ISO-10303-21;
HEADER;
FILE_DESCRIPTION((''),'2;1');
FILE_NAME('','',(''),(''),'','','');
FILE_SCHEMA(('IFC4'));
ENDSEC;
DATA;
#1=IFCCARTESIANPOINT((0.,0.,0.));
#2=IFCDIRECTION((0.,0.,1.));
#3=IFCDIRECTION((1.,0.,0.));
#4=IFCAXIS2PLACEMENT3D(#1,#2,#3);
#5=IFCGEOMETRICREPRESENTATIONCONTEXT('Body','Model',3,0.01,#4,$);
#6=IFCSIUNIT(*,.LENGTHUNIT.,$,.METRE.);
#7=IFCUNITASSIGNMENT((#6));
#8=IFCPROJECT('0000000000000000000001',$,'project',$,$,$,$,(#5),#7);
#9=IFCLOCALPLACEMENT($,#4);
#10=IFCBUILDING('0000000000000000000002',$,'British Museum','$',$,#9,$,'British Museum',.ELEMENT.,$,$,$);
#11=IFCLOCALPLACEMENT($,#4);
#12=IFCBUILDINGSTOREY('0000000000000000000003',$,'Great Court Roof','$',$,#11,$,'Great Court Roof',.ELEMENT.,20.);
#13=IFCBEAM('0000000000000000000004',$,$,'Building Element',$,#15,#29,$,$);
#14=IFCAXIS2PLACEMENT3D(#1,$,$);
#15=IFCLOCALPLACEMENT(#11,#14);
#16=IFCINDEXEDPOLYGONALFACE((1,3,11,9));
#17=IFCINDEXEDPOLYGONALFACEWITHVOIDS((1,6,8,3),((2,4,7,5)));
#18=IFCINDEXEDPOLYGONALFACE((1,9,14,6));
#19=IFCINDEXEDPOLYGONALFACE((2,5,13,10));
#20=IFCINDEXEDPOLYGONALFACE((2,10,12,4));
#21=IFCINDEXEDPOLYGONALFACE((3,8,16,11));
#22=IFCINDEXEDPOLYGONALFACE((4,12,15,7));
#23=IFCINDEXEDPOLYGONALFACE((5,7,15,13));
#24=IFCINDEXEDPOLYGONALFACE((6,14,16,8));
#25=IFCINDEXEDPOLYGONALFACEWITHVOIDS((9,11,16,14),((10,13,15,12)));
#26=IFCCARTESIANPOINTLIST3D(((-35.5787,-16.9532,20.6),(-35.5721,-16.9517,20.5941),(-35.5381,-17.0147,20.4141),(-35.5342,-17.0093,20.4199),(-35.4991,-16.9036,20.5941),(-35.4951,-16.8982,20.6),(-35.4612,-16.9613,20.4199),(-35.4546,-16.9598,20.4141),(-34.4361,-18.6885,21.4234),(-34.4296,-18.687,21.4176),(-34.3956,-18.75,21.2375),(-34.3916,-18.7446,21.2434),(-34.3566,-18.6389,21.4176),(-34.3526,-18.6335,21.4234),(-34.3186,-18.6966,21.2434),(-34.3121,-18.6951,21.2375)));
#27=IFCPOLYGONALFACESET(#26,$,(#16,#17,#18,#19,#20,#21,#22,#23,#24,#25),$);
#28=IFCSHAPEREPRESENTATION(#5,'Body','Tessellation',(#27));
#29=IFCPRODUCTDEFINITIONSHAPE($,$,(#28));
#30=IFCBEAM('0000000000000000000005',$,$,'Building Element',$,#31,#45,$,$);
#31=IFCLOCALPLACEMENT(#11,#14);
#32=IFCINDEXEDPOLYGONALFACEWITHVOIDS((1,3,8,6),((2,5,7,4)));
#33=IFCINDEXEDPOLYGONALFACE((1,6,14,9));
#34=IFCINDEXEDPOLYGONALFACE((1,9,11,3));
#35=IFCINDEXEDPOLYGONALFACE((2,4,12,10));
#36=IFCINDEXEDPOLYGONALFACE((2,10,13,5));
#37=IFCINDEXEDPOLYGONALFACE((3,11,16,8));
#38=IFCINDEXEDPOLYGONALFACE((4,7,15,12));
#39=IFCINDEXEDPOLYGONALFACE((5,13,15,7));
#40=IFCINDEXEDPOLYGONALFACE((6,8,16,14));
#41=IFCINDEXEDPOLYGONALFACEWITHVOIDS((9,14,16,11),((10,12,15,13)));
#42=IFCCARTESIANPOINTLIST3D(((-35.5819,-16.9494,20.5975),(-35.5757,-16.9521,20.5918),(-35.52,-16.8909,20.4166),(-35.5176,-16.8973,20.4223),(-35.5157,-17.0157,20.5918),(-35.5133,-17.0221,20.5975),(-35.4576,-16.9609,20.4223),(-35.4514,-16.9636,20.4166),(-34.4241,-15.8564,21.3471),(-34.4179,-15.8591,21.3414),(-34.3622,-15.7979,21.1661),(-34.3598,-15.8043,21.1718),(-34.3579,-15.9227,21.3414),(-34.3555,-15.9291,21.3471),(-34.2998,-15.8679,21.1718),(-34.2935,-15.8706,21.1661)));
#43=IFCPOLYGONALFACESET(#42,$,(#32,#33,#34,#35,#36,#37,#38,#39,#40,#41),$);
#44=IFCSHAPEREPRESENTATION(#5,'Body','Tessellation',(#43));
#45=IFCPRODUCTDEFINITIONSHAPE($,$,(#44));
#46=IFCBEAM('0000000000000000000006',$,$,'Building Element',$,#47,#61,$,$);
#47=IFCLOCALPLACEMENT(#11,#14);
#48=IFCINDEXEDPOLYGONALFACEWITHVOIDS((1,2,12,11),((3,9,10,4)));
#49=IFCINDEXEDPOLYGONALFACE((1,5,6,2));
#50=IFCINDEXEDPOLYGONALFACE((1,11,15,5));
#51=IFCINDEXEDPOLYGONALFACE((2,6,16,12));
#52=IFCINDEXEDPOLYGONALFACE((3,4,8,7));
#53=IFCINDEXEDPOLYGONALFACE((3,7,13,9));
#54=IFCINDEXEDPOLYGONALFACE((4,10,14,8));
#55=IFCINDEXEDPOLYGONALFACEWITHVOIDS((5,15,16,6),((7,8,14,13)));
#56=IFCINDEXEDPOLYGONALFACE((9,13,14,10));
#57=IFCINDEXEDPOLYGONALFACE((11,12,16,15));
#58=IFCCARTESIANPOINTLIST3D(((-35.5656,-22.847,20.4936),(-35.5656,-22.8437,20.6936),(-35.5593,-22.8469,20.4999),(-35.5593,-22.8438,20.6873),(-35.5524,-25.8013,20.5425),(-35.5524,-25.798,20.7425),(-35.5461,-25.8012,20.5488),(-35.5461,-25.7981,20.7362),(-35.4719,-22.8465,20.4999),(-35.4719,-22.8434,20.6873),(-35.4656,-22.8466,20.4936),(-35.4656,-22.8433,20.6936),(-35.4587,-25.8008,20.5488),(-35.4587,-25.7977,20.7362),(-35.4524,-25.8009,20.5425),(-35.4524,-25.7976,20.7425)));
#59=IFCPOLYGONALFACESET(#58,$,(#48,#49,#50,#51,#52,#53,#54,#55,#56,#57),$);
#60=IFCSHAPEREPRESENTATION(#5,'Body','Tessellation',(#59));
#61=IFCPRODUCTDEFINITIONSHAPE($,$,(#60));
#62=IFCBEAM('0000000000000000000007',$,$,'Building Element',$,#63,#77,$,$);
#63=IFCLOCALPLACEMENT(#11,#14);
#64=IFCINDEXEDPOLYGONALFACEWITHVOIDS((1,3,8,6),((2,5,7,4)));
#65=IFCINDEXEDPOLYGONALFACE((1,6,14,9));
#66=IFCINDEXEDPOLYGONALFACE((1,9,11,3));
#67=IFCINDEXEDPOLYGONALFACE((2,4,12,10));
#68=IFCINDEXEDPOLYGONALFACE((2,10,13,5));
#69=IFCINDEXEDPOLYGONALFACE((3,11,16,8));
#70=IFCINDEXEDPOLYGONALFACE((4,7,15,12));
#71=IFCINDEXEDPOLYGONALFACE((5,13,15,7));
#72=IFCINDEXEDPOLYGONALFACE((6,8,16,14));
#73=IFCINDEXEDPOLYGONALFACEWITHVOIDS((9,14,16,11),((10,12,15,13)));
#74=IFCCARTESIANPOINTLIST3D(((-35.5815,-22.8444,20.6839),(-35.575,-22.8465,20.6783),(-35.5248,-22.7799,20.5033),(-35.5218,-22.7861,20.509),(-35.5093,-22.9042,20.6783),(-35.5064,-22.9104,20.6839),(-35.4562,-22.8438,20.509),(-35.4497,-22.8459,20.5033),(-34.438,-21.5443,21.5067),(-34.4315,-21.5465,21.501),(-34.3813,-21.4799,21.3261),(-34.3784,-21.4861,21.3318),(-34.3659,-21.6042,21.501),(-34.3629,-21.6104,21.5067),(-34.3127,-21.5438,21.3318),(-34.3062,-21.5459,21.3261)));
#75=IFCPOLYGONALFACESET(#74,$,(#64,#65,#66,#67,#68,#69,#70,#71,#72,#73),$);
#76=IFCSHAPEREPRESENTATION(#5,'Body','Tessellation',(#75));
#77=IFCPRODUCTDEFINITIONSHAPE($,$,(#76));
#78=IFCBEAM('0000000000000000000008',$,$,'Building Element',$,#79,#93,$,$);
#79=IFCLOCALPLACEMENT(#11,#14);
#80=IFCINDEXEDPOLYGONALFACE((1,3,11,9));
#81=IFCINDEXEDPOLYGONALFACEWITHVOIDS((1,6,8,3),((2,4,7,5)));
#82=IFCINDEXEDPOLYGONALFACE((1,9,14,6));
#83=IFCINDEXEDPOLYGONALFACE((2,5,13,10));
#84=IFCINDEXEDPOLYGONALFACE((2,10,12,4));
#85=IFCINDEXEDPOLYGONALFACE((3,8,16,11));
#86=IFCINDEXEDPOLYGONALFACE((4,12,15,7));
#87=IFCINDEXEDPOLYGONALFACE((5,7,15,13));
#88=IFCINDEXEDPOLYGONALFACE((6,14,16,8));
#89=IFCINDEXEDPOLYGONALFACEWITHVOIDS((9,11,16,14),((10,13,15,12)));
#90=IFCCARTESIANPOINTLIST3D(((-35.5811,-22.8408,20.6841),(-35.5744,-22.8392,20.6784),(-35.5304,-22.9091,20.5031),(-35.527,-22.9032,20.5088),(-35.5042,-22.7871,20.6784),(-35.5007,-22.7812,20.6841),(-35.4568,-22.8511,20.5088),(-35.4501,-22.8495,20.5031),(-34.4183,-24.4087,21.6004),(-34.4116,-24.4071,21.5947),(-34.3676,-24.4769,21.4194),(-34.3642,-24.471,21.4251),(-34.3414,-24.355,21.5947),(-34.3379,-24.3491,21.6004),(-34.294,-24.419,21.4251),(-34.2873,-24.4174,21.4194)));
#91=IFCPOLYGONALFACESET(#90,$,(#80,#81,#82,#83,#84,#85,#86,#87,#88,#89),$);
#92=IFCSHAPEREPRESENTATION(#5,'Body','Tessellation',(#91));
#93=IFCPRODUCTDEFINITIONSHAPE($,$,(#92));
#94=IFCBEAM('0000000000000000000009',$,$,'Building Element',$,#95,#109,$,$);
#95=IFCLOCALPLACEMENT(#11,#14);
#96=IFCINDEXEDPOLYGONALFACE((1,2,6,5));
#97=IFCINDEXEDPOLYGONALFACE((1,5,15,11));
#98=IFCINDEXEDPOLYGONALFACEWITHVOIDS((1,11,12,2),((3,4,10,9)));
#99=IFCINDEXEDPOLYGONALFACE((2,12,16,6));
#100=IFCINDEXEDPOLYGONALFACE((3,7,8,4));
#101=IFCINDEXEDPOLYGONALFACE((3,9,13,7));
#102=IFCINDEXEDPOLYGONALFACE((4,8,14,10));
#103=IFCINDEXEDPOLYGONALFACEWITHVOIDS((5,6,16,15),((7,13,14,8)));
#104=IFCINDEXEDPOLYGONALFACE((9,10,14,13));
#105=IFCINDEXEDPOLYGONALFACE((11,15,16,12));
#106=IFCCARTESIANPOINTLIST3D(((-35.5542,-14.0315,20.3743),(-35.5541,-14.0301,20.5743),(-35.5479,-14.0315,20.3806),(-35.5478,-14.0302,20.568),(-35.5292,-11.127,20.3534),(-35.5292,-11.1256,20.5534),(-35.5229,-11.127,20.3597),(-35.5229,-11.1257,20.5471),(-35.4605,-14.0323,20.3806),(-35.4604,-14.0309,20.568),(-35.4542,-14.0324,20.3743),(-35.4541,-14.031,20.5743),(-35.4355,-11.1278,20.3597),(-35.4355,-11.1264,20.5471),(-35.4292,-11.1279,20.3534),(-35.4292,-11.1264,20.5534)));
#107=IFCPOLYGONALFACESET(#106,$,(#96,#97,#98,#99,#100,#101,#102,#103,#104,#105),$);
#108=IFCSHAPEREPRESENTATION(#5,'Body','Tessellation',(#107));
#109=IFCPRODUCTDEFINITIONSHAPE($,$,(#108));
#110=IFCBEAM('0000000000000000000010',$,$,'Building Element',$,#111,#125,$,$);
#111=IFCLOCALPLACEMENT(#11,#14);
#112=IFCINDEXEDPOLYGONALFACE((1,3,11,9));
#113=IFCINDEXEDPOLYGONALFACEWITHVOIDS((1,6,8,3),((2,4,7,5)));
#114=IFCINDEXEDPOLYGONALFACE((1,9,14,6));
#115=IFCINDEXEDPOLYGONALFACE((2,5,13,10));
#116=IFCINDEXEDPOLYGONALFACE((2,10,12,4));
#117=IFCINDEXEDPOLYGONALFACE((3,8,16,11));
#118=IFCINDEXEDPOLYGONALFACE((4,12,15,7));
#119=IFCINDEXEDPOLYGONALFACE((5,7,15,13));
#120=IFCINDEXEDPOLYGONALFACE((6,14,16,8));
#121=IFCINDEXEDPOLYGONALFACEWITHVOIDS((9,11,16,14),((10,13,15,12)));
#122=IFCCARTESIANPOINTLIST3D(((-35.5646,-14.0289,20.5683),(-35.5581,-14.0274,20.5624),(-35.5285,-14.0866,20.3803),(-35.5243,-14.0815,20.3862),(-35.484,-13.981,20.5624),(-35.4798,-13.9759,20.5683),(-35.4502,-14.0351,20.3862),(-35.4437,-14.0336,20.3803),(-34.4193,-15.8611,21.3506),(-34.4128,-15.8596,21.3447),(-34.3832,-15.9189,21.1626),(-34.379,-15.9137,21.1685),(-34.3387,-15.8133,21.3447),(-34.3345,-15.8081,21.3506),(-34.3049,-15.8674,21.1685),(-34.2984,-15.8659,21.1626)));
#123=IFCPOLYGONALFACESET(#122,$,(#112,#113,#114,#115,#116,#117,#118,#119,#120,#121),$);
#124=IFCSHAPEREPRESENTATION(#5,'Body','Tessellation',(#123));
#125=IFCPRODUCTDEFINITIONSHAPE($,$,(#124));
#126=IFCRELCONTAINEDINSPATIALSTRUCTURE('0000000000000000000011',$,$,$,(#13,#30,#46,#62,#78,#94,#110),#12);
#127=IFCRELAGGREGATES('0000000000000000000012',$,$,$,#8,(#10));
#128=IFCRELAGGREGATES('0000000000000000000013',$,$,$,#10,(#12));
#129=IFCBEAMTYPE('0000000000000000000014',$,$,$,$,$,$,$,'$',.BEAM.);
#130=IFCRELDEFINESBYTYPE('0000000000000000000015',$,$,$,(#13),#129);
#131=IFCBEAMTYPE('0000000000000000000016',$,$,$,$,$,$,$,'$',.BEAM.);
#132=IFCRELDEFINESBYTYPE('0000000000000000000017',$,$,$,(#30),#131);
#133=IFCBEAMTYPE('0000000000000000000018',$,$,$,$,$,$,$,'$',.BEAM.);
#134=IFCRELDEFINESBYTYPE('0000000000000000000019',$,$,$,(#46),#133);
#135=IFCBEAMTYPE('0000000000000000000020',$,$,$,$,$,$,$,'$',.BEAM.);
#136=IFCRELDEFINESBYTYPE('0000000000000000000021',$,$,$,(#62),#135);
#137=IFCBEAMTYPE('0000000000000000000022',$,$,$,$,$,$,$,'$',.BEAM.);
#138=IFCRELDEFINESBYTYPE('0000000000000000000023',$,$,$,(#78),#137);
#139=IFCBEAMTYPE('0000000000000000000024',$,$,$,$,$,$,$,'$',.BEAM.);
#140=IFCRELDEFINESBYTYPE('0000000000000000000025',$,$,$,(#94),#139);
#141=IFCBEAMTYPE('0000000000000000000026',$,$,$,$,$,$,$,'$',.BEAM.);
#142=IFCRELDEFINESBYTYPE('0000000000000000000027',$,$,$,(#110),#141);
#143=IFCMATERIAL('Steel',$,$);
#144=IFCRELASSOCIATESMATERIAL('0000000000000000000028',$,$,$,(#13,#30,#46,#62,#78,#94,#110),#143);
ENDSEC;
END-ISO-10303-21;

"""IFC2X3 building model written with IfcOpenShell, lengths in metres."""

from ifc_helpers import new_model, si_unit, frame, origin_with_axes, origin_2d, place, context, project, spatial, hollow_rectangle, extrude, material, type_object, element, save


model = new_model("IFC2X3")

# Units and contexts
model_context = context("Model", 3, precision=0.01, world=origin_with_axes(), identifier="Body")
ifc_project = project(units=[si_unit("LENGTHUNIT", "METRE")], contexts=[model_context])

# Building, storey
building_placement = place(None, origin_with_axes())
building = spatial("IfcBuilding", under=ifc_project, at=building_placement, Name="British Museum", Description="$", LongName="British Museum", CompositionType="ELEMENT")
storey_placement = place(None, origin_with_axes())
storey = spatial("IfcBuildingStorey", under=building, at=storey_placement, Name="Great Court Roof", Description="$", LongName="Great Court Roof", CompositionType="ELEMENT", Elevation=20.0)

# Beams
ifc_material = material(Name="Steel")
beam_type_1 = type_object("IfcBeamType", ElementType="$", PredefinedType="BEAM")
beam_1_placement = place(None, origin_with_axes())
element("IfcBeam", 1, at=beam_1_placement, inside=storey, type_object=beam_type_1, material=ifc_material, Description="Building Element", context=model_context, shape_type="SweptSolid", body=[
    extrude(hollow_rectangle(XDim=0.1, YDim=0.2, WallThickness=0.0063, InnerFilletRadius=-0.0063, OuterFilletRadius=0.0, at=origin_2d()), frame((-35.5166, -16.9565, 20.507), z_axis=(0.511233, -0.77646, 0.368444), x_axis=(0.835217, 0.54992, 0.0)), (0.0, 0.0, 1.0), 2.2349),
])
beam_type_2 = type_object("IfcBeamType", ElementType="$", PredefinedType="BEAM")
beam_2_placement = place(None, origin_with_axes())
element("IfcBeam", 2, at=beam_2_placement, inside=storey, type_object=beam_type_2, material=ifc_material, Description="Building Element", context=model_context, shape_type="SweptSolid", body=[
    extrude(hollow_rectangle(XDim=0.1, YDim=0.2, WallThickness=0.0063, InnerFilletRadius=-0.0063, OuterFilletRadius=0.0, at=origin_2d()), frame((-35.5166, -16.9565, 20.507), z_axis=(0.657915, 0.621073, 0.42593), x_axis=(-0.686453, 0.727174, 0.0)), (0.0, 0.0, 1.0), 1.7598),
])
beam_type_3 = type_object("IfcBeamType", ElementType="$", PredefinedType="BEAM")
beam_3_placement = place(None, origin_with_axes())
element("IfcBeam", 3, at=beam_3_placement, inside=storey, type_object=beam_type_3, material=ifc_material, Description="Building Element", context=model_context, shape_type="SweptSolid", body=[
    extrude(hollow_rectangle(XDim=0.1, YDim=0.2, WallThickness=0.0063, InnerFilletRadius=-0.0063, OuterFilletRadius=0.0, at=origin_2d()), frame((-35.5156, -22.8452, 20.5936), z_axis=(0.004464, -0.999853, 0.016544), x_axis=(0.99999, 0.004465, 0.0)), (0.0, 0.0, 1.0), 2.9547),
])
beam_type_4 = type_object("IfcBeamType", ElementType="$", PredefinedType="BEAM")
beam_4_placement = place(None, origin_with_axes())
element("IfcBeam", 4, at=beam_4_placement, inside=storey, type_object=beam_type_4, material=ifc_material, Description="Building Element", context=model_context, shape_type="SweptSolid", body=[
    extrude(hollow_rectangle(XDim=0.1, YDim=0.2, WallThickness=0.0063, InnerFilletRadius=-0.0063, OuterFilletRadius=0.0, at=origin_2d()), frame((-35.5156, -22.8452, 20.5936), z_axis=(0.596521, 0.678188, 0.429213), x_axis=(-0.75087, 0.66045, 0.0)), (0.0, 0.0, 1.0), 1.9169),
])
beam_type_5 = type_object("IfcBeamType", ElementType="$", PredefinedType="BEAM")
beam_5_placement = place(None, origin_with_axes())
element("IfcBeam", 5, at=beam_5_placement, inside=storey, type_object=beam_type_5, material=ifc_material, Description="Building Element", context=model_context, shape_type="SweptSolid", body=[
    extrude(hollow_rectangle(XDim=0.1, YDim=0.2, WallThickness=0.0063, InnerFilletRadius=-0.0063, OuterFilletRadius=0.0, at=origin_2d()), frame((-35.5156, -22.8452, 20.5936), z_axis=(0.539247, -0.727091, 0.424914), x_axis=(0.803207, 0.595699, 0.0)), (0.0, 0.0, 1.0), 2.1563),
])
beam_type_6 = type_object("IfcBeamType", ElementType="$", PredefinedType="BEAM")
beam_6_placement = place(None, origin_with_axes())
element("IfcBeam", 6, at=beam_6_placement, inside=storey, type_object=beam_type_6, material=ifc_material, Description="Building Element", context=model_context, shape_type="SweptSolid", body=[
    extrude(hollow_rectangle(XDim=0.1, YDim=0.2, WallThickness=0.0063, InnerFilletRadius=-0.0063, OuterFilletRadius=0.0, at=origin_2d()), frame((-35.5042, -14.0312, 20.4743), z_axis=(0.008594, 0.999937, -0.007192), x_axis=(-0.999963, 0.008594, 0.0)), (0.0, 0.0, 1.0), 2.9047),
])
beam_type_7 = type_object("IfcBeamType", ElementType="$", PredefinedType="BEAM")
beam_7_placement = place(None, origin_with_axes())
element("IfcBeam", 7, at=beam_7_placement, inside=storey, type_object=beam_type_7, material=ifc_material, Description="Building Element", context=model_context, shape_type="SweptSolid", body=[
    extrude(hollow_rectangle(XDim=0.1, YDim=0.2, WallThickness=0.0063, InnerFilletRadius=-0.0063, OuterFilletRadius=0.0, at=origin_2d()), frame((-35.5042, -14.0312, 20.4743), z_axis=(0.498389, -0.79732, 0.340425), x_axis=(0.847968, 0.530048, 0.0)), (0.0, 0.0, 1.0), 2.298),
])

save(model, "model.ifc")
